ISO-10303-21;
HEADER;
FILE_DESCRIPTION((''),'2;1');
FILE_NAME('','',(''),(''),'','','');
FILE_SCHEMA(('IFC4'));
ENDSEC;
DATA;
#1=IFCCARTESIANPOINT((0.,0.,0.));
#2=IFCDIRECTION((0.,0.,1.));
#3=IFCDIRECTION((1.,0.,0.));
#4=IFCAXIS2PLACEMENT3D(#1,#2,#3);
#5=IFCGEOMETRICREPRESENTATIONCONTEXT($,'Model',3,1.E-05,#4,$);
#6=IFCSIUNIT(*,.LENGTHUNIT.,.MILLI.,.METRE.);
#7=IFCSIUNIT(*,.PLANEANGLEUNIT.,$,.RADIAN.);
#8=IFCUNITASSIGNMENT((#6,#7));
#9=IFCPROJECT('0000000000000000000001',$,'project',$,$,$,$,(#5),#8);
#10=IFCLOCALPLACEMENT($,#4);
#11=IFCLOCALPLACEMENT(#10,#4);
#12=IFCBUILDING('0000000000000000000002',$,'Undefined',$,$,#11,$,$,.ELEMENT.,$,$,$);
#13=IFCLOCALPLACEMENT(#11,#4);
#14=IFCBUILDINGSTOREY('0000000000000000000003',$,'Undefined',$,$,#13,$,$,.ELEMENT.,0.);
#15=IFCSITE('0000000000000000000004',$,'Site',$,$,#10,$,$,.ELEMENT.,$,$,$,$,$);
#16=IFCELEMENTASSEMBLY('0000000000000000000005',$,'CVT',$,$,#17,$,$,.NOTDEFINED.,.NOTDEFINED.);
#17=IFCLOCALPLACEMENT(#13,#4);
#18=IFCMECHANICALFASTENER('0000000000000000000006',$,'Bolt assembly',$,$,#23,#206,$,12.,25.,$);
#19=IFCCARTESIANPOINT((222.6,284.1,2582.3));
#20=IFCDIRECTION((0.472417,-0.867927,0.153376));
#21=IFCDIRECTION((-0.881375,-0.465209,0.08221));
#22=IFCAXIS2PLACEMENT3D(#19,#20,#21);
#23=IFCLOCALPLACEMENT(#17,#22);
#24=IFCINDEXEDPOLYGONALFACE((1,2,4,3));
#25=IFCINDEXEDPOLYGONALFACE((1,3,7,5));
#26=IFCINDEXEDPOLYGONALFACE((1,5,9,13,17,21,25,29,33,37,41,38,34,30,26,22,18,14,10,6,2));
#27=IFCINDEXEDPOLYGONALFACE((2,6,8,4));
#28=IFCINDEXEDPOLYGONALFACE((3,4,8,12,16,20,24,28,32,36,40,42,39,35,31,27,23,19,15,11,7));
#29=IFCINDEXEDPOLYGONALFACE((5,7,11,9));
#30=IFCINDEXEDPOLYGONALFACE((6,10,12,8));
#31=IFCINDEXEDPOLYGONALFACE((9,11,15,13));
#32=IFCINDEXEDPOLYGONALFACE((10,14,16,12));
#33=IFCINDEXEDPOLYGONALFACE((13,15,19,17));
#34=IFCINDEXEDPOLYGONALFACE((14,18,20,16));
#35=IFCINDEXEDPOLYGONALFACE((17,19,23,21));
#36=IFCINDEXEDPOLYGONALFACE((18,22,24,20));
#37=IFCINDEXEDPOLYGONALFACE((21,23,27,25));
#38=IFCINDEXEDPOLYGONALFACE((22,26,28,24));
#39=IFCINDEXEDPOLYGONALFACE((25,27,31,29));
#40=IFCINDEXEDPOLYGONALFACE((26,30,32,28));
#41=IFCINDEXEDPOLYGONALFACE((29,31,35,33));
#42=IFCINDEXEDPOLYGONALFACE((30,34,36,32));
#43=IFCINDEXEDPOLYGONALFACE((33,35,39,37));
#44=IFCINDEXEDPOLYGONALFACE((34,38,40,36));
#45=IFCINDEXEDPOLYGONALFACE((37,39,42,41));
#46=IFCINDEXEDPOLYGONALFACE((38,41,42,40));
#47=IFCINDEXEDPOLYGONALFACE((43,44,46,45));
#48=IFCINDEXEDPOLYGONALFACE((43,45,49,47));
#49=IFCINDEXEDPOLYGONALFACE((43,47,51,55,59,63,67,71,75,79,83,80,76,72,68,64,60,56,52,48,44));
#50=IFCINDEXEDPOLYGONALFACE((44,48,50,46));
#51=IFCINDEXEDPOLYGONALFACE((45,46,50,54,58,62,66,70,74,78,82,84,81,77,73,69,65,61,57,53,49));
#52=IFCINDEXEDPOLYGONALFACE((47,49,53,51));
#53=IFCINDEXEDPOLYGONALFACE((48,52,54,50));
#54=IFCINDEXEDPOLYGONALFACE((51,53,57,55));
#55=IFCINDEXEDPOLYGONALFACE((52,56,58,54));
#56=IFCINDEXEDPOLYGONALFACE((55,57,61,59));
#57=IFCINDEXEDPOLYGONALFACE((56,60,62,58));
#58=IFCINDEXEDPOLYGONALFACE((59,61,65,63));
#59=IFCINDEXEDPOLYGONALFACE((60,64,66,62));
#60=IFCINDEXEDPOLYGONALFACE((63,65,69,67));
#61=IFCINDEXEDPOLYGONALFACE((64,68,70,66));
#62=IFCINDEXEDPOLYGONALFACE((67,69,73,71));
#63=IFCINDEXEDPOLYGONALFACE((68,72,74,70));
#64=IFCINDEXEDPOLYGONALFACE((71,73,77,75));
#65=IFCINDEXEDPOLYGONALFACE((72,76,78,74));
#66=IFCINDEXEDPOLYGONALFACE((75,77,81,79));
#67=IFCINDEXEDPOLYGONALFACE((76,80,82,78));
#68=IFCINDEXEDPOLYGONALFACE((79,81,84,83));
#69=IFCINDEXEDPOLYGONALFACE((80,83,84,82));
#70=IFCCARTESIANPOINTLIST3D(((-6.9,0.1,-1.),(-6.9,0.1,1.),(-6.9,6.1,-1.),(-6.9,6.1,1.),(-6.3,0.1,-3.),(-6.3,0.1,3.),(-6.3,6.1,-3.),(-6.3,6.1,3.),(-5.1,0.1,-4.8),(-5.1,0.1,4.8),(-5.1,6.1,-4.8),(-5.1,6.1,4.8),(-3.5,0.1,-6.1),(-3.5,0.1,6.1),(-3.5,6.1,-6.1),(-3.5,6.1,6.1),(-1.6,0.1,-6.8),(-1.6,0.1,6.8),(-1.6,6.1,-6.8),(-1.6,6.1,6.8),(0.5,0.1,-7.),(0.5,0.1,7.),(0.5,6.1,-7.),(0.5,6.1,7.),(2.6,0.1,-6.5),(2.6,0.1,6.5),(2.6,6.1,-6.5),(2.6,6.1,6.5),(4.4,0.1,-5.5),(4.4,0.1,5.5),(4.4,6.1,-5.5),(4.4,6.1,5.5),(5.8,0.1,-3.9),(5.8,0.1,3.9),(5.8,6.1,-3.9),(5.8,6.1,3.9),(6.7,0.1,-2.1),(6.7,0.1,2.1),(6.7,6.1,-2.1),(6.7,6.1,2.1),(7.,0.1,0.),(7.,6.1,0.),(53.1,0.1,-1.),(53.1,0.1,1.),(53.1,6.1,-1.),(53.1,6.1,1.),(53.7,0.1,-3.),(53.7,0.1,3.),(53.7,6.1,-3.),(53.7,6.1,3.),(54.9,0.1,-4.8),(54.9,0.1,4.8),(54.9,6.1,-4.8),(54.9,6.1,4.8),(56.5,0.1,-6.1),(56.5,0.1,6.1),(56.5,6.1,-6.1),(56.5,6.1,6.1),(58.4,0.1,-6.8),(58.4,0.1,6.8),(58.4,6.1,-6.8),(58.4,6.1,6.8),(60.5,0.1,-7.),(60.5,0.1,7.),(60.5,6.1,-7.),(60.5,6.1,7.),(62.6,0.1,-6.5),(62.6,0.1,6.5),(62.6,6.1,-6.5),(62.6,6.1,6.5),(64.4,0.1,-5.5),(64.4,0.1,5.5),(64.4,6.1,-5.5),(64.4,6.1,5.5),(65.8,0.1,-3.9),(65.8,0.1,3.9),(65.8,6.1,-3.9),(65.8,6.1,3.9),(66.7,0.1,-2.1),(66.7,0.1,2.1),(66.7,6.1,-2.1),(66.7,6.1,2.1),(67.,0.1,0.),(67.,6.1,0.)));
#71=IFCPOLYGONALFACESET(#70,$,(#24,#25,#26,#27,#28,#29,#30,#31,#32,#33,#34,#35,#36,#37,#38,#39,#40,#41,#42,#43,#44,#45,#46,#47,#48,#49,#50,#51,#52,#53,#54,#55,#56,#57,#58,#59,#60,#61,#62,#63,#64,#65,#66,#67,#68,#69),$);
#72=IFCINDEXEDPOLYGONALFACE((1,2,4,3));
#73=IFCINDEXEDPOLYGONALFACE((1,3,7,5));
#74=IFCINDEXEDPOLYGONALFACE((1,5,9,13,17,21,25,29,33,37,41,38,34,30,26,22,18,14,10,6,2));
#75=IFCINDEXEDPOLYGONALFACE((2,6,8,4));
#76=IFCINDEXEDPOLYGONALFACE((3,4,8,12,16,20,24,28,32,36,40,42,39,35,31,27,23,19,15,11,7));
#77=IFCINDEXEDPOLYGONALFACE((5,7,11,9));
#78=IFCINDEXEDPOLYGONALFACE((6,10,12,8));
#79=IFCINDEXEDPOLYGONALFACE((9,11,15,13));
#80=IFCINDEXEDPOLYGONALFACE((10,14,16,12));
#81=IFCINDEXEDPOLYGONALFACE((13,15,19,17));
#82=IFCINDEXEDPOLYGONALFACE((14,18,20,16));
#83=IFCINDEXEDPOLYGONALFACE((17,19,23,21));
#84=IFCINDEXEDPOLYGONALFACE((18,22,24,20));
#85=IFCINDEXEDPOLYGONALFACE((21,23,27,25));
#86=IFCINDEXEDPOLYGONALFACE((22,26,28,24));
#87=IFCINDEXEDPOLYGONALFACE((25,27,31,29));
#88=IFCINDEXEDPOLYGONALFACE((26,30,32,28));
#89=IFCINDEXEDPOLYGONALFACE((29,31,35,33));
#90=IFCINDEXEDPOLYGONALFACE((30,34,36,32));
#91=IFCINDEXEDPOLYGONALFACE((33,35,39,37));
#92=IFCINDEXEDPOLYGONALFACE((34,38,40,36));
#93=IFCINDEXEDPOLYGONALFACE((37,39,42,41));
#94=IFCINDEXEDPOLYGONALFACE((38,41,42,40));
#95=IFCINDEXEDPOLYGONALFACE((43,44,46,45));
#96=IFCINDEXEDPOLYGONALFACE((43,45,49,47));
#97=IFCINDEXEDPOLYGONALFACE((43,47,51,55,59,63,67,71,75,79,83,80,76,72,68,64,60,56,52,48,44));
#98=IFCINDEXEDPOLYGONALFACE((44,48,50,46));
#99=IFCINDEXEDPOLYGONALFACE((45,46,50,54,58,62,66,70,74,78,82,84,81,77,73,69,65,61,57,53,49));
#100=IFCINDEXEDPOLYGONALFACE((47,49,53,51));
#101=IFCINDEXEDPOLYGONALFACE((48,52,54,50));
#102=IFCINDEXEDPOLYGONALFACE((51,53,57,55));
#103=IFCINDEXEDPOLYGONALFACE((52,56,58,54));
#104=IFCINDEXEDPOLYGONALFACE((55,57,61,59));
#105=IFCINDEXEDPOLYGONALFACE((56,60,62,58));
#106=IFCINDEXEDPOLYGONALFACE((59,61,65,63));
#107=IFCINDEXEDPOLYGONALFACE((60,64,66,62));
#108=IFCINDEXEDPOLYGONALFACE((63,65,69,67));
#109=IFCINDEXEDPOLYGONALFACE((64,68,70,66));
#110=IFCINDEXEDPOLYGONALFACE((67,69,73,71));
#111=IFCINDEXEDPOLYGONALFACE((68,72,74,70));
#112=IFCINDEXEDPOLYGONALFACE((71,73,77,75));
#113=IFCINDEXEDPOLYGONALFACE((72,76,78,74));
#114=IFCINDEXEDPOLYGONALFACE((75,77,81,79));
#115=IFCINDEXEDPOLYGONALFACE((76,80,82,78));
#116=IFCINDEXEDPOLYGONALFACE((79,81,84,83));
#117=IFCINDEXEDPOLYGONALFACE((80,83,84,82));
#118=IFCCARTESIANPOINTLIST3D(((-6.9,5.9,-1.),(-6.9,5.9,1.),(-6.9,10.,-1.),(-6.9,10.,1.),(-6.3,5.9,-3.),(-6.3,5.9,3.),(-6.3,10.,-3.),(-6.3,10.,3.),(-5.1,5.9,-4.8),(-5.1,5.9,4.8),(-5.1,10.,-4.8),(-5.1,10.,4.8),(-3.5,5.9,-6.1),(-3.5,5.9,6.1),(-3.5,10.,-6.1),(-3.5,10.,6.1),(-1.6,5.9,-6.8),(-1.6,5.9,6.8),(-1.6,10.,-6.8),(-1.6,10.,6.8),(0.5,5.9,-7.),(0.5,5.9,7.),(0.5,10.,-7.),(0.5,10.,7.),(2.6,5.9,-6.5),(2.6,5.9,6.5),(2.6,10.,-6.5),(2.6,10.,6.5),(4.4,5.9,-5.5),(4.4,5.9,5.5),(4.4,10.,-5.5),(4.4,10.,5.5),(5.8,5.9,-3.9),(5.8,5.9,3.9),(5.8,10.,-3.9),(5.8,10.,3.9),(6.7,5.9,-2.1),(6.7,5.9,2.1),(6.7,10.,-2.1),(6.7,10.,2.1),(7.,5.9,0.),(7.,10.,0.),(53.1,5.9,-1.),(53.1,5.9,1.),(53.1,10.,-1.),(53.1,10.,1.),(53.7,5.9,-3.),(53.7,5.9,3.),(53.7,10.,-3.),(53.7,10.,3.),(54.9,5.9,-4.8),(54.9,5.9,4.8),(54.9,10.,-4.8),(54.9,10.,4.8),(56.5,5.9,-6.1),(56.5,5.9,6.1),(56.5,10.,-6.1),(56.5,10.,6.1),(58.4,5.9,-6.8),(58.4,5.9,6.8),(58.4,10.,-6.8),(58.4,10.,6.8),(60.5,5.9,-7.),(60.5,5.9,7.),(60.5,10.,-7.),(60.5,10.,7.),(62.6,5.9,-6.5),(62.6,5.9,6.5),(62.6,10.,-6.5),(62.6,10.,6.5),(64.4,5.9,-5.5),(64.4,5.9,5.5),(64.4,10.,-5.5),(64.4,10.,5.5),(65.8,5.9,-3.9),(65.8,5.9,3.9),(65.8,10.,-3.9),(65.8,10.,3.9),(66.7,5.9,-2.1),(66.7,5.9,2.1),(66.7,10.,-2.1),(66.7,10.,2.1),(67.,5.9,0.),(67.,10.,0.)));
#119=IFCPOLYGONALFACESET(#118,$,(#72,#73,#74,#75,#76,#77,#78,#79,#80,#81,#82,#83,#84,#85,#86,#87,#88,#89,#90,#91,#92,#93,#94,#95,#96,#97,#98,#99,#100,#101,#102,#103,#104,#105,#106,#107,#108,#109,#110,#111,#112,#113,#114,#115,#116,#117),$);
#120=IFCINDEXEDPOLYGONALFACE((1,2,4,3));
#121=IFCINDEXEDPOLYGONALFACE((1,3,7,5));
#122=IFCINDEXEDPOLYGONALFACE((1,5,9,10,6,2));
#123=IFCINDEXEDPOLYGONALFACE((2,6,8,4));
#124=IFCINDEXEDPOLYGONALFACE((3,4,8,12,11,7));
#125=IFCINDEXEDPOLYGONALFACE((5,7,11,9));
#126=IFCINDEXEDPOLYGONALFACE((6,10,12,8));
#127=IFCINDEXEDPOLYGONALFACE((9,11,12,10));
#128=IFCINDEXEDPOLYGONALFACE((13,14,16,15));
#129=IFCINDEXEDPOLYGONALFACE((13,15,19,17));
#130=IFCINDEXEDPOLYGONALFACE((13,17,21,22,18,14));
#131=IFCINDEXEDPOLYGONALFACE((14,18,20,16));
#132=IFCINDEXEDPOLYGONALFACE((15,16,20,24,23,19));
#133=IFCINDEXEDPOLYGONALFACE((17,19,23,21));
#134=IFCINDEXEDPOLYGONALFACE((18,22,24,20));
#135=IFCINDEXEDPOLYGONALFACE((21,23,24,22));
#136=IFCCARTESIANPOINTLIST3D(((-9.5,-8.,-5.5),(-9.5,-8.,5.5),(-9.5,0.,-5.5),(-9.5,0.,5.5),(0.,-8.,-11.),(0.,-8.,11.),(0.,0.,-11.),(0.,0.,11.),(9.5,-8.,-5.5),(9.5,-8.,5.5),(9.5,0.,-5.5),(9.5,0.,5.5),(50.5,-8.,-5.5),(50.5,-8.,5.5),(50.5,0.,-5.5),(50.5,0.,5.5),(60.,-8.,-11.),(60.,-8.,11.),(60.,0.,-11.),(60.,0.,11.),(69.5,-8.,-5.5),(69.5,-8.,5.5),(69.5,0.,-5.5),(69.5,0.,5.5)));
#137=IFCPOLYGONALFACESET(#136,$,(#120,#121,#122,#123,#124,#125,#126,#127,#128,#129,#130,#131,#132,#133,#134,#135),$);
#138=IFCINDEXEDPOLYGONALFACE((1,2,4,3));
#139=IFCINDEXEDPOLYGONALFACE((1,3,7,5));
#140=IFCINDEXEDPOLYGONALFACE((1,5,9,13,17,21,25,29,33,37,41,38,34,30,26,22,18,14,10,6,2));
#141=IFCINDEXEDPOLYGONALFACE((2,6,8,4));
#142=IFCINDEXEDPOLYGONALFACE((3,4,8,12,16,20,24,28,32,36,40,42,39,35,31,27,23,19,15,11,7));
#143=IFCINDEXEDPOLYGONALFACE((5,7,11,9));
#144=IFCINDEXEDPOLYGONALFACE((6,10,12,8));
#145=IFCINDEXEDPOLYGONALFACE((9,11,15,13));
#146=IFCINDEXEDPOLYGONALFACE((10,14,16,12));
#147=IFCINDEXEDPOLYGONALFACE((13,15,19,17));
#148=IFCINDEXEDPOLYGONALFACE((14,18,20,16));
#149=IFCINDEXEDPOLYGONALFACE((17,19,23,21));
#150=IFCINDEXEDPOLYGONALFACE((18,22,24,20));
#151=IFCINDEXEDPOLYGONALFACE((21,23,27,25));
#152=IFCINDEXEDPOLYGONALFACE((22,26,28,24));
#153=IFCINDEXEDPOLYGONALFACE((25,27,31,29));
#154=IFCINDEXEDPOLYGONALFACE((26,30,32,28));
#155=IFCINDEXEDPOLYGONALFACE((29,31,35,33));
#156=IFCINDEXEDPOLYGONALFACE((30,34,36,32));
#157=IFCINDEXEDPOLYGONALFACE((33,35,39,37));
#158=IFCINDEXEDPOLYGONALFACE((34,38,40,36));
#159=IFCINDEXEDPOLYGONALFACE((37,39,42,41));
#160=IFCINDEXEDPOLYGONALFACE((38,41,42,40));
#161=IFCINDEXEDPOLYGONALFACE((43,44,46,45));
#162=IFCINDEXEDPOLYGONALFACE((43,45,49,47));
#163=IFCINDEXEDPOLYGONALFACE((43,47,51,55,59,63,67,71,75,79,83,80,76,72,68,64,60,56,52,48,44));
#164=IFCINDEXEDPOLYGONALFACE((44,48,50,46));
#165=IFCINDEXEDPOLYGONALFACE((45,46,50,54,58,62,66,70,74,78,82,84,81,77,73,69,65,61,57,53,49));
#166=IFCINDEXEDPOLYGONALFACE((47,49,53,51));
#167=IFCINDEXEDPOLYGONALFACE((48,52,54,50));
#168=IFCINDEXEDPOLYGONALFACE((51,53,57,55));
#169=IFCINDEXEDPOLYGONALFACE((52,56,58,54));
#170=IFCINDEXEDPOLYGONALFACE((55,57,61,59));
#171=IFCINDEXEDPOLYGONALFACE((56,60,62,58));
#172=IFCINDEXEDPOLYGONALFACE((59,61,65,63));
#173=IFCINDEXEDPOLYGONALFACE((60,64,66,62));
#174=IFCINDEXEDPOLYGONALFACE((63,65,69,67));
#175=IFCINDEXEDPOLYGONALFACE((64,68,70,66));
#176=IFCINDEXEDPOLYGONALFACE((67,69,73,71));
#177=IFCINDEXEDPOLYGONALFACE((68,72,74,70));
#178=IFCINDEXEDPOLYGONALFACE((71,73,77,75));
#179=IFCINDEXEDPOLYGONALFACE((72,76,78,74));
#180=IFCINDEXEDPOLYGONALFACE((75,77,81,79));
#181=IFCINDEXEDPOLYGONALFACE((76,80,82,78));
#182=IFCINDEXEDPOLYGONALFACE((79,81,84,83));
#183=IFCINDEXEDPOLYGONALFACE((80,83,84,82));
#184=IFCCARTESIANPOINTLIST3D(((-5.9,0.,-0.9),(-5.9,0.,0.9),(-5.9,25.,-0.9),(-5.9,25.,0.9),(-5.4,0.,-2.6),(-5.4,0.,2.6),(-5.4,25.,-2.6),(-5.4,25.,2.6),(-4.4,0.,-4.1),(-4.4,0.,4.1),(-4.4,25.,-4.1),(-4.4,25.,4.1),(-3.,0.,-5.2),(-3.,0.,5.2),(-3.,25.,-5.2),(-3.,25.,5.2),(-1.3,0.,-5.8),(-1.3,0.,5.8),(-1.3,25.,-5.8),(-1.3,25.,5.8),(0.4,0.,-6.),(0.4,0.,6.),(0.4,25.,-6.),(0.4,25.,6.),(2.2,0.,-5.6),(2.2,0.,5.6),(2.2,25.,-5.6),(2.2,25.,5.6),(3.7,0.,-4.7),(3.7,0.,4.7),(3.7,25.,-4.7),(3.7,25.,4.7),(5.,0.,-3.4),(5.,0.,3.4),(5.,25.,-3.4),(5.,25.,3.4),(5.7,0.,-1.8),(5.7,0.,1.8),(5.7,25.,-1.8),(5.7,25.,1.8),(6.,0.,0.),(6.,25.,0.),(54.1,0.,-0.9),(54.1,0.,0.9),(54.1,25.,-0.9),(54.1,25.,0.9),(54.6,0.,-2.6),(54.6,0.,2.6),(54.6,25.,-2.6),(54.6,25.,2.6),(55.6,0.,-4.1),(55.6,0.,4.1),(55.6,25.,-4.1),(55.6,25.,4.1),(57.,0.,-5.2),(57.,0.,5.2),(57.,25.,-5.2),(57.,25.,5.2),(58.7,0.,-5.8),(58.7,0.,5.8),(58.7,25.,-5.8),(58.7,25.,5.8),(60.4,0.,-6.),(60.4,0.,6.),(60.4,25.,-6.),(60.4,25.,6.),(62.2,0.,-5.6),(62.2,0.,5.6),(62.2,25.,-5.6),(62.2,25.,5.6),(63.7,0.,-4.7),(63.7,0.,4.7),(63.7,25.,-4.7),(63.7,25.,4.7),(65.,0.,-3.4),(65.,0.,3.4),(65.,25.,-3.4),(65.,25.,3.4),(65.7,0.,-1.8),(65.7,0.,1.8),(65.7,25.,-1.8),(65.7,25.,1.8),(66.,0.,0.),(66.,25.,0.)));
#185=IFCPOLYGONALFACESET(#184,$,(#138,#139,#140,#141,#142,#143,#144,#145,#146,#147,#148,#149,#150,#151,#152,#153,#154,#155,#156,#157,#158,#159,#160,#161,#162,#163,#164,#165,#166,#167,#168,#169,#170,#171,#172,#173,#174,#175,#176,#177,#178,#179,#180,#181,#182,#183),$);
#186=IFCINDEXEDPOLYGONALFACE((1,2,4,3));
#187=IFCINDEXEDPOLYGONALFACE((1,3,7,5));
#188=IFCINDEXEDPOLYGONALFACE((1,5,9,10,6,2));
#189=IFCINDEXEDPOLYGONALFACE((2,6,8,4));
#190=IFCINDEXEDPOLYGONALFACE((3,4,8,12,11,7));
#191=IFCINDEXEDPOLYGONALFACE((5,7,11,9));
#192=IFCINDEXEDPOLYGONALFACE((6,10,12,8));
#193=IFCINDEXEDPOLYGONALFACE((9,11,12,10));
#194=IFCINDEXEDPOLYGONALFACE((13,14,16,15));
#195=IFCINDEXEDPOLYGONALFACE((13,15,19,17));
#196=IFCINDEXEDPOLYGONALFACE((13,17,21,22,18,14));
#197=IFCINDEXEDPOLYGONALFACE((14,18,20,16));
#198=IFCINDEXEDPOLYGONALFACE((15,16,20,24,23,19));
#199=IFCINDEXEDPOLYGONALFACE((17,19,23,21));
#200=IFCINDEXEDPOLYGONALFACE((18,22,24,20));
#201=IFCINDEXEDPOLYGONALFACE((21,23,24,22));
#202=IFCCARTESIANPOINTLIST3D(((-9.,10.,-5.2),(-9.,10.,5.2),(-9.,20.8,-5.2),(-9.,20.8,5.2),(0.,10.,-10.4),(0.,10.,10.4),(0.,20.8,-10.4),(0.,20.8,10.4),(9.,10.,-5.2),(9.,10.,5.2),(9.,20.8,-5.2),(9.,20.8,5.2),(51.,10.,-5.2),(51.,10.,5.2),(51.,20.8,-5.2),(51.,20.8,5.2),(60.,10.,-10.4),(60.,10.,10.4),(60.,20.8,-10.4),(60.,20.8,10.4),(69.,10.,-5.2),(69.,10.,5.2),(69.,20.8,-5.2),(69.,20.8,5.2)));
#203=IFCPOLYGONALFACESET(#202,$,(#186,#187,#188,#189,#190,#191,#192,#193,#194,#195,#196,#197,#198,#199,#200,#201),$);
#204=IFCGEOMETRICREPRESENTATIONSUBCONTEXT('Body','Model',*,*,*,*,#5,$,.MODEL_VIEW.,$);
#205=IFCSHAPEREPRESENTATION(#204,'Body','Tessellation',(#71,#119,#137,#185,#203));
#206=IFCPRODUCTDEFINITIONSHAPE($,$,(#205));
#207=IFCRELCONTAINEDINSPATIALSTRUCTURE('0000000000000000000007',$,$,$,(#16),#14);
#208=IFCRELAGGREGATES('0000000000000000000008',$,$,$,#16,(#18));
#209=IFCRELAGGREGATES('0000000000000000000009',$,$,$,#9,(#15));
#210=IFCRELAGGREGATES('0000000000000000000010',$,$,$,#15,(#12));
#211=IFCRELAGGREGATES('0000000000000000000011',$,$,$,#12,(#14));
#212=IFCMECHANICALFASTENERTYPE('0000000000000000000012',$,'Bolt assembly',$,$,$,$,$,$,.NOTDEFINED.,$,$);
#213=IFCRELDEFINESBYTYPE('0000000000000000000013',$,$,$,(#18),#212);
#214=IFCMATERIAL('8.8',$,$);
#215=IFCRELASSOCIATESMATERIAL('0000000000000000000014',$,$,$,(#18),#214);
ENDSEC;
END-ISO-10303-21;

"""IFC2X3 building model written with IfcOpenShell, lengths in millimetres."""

from ifc_helpers import new_model, si_unit, frame, origin_with_axes, origin_2d_with_axis, place, context, subcontext, project, spatial, polyline, circle, outline, extrude, source, transform, mapped, material, type_object, element, aggregate, save


model = new_model("IFC2X3")

# Units and contexts
model_context = context("Model", 3, precision=1e-05, world=origin_with_axes())
body_context = subcontext(model_context, "Body", "Model", "MODEL_VIEW")
ifc_project = project(units=[si_unit("LENGTHUNIT", "METRE", prefix="MILLI"), si_unit("PLANEANGLEUNIT", "RADIAN")], contexts=[model_context])

# Site, building, storey
site_placement = place(None, origin_with_axes())
site = spatial("IfcSite", under=ifc_project, at=site_placement, Name="Site", CompositionType="ELEMENT")
building_placement = place(site_placement, origin_with_axes())
building = spatial("IfcBuilding", under=site, at=building_placement, Name="Undefined", CompositionType="ELEMENT")
storey_placement = place(building_placement, origin_with_axes())
storey = spatial("IfcBuildingStorey", under=building, at=storey_placement, Name="Undefined", CompositionType="ELEMENT", Elevation=0.0)

# Element assembly
assembly_1_placement = place(storey_placement, origin_with_axes())
assembly_1 = element("IfcElementAssembly", 1, at=assembly_1_placement, inside=storey, Name="CVT", AssemblyPlace="NOTDEFINED", PredefinedType="NOTDEFINED")

# Shared definitions
ifc_material_1 = material(Name="8.8")
mechanical_fastener_type = type_object("IfcMechanicalFastenerType", Name="Bolt assembly")

# Mechanical fastener
shared_shape_1 = source(origin_with_axes(), body_context, "Body", "SweptSolid", [
    extrude(circle(Radius=7.0, at=origin_2d_with_axis()), frame((0.0, 0.1, 0.0), z_axis=(0.0, 1.0, 0.0), x_axis=(1.0, 0.0, 0.0)), (0.0, 0.0, 1.0), 6.0),
    extrude(circle(Radius=7.0, at=origin_2d_with_axis()), frame((0.0, 5.9, 0.0), z_axis=(0.0, 1.0, 0.0), x_axis=(1.0, 0.0, 0.0)), (0.0, 0.0, 1.0), 4.1),
    extrude(outline(polyline([(9.5, -5.5), (9.5, 5.5), (0.0, 11.0), (-9.5, 5.5), (-9.5, -5.5), (0.0, -11.0), (9.5, -5.5)])), frame((0.0, -8.0, 0.0), z_axis=(0.0, 1.0, 0.0), x_axis=(1.0, 0.0, 0.0)), (0.0, 0.0, 1.0), 8.0),
    extrude(circle(Radius=6.0, at=origin_2d_with_axis()), frame((0.0, 0.0, 0.0), z_axis=(0.0, 1.0, 0.0), x_axis=(1.0, 0.0, 0.0)), (0.0, 0.0, 1.0), 25.0),
    extrude(outline(polyline([(9.0, -5.2), (9.0, 5.2), (0.0, 10.4), (-9.0, 5.2), (-9.0, -5.2), (0.0, -10.4), (9.0, -5.2)])), frame((0.0, 10.0, 0.0), z_axis=(0.0, 1.0, 0.0), x_axis=(1.0, 0.0, 0.0)), (0.0, 0.0, 1.0), 10.8),
])
mechanical_fastener_1_placement = place(assembly_1_placement, frame((222.6, 284.1, 2582.3), z_axis=(0.472417, -0.867927, 0.153376), x_axis=(-0.881375, -0.465209, 0.08221)))
mechanical_fastener_1 = element("IfcMechanicalFastener", 2, at=mechanical_fastener_1_placement, type_object=mechanical_fastener_type, material=ifc_material_1, Name="Bolt assembly", NominalDiameter=12.0, NominalLength=25.0, context=body_context, shape_type="MappedRepresentation", body=[
    mapped(shared_shape_1, transform((0.0, 0.0, 0.0))),
    mapped(shared_shape_1, transform((60.0, 0.0, 0.0))),
])
aggregate(assembly_1, [mechanical_fastener_1])

save(model, "model.ifc")
